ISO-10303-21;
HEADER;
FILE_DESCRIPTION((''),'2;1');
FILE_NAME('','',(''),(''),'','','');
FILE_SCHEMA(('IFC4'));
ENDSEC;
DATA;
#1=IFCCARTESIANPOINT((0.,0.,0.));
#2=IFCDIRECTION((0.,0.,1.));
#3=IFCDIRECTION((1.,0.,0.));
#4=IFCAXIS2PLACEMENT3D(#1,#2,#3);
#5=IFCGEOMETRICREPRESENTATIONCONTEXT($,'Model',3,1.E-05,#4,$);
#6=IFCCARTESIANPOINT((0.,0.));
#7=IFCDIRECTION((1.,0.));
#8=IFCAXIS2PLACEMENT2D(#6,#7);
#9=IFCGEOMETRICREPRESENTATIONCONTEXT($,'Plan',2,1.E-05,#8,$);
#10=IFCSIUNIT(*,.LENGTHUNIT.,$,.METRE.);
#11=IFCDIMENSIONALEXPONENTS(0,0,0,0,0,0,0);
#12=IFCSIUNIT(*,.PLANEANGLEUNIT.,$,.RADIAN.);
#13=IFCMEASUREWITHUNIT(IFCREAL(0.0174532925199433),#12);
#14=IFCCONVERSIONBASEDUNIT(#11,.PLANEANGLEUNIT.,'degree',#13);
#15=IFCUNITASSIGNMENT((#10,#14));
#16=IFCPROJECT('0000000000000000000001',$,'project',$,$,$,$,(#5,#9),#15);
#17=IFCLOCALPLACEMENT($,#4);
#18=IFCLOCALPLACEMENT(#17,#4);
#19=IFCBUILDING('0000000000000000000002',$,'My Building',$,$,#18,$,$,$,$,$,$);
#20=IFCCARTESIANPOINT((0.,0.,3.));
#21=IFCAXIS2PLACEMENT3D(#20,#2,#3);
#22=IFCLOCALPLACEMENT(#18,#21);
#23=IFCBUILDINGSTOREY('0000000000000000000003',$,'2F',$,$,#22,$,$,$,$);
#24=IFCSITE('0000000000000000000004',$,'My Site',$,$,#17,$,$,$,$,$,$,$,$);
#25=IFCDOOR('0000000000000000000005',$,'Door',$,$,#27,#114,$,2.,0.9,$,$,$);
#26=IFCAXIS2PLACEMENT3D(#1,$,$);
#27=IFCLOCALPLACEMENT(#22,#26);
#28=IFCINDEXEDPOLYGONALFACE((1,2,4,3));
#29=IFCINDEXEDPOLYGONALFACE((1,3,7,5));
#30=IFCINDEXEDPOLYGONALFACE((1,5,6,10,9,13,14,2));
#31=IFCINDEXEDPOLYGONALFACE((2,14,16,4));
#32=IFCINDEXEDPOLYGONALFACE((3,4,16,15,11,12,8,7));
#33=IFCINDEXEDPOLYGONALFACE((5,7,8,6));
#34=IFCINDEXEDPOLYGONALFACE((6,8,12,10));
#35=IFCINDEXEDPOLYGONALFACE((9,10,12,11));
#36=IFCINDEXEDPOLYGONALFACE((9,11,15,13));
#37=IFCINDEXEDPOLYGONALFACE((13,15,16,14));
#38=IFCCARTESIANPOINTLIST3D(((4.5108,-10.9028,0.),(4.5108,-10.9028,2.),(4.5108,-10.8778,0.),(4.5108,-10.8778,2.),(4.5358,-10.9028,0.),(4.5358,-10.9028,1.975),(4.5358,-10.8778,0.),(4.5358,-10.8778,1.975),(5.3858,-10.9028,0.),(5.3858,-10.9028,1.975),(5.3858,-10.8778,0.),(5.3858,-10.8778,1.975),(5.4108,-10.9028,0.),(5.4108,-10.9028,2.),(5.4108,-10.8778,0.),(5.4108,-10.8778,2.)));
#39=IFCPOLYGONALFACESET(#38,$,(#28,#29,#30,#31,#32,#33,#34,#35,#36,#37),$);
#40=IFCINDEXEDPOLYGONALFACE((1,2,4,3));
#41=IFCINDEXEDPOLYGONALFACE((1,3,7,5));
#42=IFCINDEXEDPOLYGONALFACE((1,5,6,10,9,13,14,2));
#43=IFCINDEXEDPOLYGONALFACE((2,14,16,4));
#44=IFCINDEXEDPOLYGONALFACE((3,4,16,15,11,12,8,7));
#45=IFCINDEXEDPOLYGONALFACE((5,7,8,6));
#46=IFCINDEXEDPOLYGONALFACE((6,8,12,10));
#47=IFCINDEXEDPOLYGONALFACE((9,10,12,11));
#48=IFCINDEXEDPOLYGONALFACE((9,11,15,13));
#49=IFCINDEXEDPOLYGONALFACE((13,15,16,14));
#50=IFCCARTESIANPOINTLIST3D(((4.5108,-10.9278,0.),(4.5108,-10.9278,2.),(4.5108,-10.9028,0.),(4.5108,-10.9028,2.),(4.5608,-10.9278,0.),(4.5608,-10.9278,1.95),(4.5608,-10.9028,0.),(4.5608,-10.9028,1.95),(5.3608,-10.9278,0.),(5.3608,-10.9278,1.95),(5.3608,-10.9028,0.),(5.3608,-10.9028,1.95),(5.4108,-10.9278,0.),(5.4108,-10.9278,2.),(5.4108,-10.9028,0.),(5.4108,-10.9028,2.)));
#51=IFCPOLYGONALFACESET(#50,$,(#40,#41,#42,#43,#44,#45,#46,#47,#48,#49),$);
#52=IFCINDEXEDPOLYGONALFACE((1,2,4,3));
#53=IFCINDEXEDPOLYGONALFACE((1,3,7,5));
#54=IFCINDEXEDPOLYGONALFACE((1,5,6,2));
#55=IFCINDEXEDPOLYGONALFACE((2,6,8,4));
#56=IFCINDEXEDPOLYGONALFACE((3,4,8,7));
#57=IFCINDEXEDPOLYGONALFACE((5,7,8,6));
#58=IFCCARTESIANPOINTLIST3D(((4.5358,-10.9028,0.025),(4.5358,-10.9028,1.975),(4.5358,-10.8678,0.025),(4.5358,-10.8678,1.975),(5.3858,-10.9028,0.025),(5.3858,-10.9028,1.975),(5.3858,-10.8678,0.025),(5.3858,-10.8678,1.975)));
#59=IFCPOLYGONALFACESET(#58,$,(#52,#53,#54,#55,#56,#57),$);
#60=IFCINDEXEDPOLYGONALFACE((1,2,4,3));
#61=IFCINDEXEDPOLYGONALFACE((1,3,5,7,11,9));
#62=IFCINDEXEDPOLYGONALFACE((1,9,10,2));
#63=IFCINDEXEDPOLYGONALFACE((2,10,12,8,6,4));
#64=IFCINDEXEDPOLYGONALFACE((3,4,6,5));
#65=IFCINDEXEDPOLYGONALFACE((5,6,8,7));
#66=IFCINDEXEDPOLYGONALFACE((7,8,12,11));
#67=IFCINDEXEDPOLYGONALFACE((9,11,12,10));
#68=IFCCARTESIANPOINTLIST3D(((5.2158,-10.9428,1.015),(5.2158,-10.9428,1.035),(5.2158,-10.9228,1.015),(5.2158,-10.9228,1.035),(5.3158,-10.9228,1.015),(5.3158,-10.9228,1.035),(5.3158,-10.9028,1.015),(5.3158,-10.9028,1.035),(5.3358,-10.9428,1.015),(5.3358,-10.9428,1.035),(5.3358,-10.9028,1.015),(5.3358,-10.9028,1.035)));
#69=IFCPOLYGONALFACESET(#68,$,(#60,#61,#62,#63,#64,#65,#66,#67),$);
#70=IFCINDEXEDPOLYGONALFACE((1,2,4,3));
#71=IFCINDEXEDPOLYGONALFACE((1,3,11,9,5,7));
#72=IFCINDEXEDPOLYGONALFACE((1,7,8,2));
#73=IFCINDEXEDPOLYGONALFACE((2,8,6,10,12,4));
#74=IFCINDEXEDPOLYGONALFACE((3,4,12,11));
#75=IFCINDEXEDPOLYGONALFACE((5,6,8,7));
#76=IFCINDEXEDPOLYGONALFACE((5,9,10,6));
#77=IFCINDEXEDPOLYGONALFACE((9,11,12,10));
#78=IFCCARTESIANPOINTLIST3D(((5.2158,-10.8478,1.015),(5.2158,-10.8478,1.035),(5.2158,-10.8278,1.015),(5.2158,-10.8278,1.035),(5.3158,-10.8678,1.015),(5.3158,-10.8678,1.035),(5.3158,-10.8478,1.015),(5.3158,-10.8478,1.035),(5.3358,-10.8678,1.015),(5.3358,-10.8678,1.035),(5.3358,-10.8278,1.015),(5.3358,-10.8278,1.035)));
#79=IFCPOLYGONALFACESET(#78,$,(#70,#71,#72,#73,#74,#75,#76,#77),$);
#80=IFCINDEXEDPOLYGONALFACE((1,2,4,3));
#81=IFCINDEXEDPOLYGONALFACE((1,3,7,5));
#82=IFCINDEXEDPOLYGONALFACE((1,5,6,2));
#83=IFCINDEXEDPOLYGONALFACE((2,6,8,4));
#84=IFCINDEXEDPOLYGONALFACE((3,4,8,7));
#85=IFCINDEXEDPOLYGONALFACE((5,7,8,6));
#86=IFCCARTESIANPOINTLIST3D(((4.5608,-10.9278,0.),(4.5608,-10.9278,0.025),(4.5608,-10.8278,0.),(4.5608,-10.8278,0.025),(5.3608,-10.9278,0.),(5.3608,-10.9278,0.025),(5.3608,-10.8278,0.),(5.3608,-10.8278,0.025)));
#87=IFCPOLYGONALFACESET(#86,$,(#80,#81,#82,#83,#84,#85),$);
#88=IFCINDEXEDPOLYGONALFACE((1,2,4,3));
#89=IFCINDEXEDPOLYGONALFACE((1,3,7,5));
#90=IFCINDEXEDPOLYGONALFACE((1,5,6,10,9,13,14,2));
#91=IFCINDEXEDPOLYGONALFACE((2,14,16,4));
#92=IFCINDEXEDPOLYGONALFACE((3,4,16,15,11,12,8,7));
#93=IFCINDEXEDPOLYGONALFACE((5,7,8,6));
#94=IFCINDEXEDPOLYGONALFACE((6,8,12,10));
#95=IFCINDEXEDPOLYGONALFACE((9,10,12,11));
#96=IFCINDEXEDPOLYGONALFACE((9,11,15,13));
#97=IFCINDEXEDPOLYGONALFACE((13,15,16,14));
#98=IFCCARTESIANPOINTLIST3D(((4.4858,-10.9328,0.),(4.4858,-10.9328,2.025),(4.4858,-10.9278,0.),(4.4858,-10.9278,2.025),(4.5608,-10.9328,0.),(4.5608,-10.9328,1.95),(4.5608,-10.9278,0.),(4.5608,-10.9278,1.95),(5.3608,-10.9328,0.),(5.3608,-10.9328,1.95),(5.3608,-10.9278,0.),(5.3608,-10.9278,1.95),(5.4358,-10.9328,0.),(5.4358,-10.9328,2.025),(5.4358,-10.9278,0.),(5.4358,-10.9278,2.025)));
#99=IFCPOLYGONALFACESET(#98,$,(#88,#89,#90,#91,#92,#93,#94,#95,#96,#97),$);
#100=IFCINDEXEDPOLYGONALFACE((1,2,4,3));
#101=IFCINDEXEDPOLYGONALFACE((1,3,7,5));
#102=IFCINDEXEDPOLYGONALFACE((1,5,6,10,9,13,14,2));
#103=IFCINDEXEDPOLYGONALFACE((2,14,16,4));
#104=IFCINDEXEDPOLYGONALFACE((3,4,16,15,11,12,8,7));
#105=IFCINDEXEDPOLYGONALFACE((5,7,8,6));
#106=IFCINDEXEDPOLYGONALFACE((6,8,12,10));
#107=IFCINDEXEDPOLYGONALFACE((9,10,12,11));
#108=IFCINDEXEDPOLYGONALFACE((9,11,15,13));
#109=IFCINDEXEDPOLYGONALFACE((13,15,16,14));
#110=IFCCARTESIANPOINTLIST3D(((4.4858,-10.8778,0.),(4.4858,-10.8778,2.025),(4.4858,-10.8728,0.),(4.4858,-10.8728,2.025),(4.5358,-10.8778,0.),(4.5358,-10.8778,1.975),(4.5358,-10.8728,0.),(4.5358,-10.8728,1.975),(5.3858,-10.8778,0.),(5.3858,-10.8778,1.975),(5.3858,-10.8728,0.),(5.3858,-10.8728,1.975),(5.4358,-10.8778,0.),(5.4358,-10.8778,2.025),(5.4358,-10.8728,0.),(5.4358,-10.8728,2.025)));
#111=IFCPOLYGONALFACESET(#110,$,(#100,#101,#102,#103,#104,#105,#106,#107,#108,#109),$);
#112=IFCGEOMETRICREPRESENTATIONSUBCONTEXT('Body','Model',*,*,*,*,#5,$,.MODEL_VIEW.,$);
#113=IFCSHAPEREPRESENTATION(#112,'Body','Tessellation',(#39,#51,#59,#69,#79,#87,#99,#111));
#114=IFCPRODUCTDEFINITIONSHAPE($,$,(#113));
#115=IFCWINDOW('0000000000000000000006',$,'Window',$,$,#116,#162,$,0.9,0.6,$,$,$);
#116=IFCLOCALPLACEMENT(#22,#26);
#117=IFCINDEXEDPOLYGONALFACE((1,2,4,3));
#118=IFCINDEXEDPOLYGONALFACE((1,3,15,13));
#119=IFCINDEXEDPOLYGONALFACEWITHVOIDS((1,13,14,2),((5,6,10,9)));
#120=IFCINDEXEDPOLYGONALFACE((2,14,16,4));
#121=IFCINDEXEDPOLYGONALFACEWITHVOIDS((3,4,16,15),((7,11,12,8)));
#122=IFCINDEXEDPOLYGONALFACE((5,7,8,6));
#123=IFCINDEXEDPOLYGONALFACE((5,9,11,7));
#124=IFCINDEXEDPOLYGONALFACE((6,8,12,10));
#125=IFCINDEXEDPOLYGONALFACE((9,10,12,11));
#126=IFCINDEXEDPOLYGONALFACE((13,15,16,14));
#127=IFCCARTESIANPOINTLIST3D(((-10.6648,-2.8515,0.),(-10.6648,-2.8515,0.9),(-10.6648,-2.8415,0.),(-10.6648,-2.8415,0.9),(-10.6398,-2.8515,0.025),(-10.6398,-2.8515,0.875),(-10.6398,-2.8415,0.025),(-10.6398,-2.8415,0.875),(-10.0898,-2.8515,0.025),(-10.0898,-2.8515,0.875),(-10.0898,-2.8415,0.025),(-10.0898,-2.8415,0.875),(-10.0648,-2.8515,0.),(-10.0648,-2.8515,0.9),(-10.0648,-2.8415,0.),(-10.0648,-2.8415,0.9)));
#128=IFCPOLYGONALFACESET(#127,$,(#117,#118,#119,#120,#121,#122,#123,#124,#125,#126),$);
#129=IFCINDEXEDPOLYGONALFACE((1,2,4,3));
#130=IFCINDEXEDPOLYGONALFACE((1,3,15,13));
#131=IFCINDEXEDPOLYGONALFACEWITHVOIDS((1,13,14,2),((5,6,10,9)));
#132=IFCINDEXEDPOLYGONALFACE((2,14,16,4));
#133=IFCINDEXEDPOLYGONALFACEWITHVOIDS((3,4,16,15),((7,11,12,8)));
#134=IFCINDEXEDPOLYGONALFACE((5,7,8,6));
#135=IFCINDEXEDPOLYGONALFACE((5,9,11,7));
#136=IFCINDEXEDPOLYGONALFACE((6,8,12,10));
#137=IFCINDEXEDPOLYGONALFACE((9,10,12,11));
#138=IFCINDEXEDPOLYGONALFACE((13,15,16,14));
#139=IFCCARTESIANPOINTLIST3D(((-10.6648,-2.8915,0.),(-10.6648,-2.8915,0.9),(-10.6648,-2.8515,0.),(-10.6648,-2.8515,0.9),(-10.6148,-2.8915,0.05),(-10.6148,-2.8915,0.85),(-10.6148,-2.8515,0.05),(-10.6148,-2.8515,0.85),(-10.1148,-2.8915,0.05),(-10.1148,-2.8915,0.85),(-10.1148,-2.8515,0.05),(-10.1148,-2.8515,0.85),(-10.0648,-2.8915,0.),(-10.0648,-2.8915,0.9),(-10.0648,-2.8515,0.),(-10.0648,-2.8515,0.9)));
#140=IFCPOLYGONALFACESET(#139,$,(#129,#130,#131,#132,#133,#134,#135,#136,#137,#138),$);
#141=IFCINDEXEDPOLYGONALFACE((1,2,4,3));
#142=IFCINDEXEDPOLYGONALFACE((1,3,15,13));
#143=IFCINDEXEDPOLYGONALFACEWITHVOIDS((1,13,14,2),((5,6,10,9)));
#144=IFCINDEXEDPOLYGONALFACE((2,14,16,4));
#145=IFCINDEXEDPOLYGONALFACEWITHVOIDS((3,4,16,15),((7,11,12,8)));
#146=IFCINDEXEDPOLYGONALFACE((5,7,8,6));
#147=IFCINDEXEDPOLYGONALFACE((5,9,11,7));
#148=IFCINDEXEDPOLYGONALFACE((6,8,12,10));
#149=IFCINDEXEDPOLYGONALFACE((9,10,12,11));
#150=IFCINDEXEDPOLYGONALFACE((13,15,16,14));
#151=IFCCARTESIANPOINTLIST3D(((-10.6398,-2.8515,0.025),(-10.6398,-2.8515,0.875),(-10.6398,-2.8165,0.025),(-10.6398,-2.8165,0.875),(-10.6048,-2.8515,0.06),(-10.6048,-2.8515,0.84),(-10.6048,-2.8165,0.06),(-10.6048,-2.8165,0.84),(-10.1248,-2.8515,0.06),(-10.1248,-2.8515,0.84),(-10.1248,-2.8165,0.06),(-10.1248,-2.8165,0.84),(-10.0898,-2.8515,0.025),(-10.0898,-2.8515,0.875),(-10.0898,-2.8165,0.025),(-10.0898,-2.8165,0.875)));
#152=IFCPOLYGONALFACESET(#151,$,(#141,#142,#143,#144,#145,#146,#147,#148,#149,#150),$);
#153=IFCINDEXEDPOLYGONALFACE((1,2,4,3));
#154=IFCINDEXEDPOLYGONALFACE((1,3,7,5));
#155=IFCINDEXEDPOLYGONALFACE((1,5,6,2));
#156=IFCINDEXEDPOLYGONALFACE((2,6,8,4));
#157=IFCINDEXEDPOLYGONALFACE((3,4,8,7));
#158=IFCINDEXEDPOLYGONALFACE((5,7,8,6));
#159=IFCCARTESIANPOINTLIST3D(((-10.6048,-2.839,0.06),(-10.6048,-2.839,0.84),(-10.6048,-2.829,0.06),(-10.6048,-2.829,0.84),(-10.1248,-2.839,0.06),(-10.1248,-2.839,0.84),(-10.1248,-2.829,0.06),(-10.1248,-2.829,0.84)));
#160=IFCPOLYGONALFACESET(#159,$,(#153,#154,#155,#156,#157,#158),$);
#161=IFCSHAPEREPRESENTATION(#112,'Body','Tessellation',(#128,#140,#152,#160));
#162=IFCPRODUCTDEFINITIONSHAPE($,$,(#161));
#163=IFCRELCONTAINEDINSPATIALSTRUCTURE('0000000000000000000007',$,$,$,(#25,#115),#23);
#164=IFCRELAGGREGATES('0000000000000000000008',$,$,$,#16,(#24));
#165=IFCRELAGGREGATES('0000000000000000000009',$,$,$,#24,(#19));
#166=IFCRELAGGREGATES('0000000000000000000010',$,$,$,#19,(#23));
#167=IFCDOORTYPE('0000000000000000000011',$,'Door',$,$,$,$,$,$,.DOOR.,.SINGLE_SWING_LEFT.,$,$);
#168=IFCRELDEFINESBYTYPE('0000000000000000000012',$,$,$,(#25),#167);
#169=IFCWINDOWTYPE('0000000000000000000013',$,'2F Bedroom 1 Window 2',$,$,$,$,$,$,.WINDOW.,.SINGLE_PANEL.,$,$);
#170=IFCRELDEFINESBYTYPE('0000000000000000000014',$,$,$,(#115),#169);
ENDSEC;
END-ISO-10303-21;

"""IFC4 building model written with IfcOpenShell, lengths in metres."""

from ifc_helpers import new_model, entity, si_unit, converted_unit, frame, origin_with_axes, origin_2d_with_axis, place, context, subcontext, project, spatial, line, indexed_curve, outline, extrude, shape, source, transform, mapped, type_object, type_shapes, element, save


model = new_model("IFC4")

# Units and contexts
model_context = context("Model", 3, precision=1e-05, world=origin_with_axes())
plan_context = context("Plan", 2, precision=1e-05, world=origin_2d_with_axis())
body_context_1 = subcontext(model_context, "Body", "Model", "MODEL_VIEW")
body_context_2 = subcontext(plan_context, "Body", "Plan", "PLAN_VIEW")
ifc_project = project(units=[si_unit("LENGTHUNIT", "METRE"), converted_unit("PLANEANGLEUNIT", "degree", entity("IfcReal", 0.0174532925199433), si_unit("PLANEANGLEUNIT", "RADIAN"), dimensions=[0, 0, 0, 0, 0, 0, 0])], contexts=[model_context, plan_context])

# Site, building, storey
site_placement = place(None, origin_with_axes())
site = spatial("IfcSite", under=ifc_project, at=site_placement, Name="My Site")
building_placement = place(site_placement, origin_with_axes())
building = spatial("IfcBuilding", under=site, at=building_placement, Name="My Building")
storey_placement = place(building_placement, frame((0.0, 0.0, 3.0), z_axis=(0.0, 0.0, 1.0), x_axis=(1.0, 0.0, 0.0)))
storey = spatial("IfcBuildingStorey", under=building, at=storey_placement, Name="2F")

# Shared definitions
door_type_1 = type_object("IfcDoorType", Name="Door", OperationType="SINGLE_SWING_LEFT", PredefinedType="DOOR")
shared_shape_1 = source(origin_with_axes(), body_context_1, "Body", "SweptSolid", [
    extrude(outline(indexed_curve([(0.0, 0.0), (0.0, 2.0), (0.9, 2.0), (0.9, 0.0), (0.875, 0.0), (0.875, 1.975), (0.025, 1.975), (0.025, 0.0)], segments=[line(1, 2, 3, 4, 5, 6, 7, 8, 1)])), frame((0.0, 0.025, 0.0), z_axis=(0.0, -1.0, 0.0), x_axis=(1.0, 0.0, 0.0)), (0.0, 0.0, -1.0), 0.025),
    extrude(outline(indexed_curve([(0.0, 0.0), (0.0, 2.0), (0.9, 2.0), (0.9, 0.0), (0.85, 0.0), (0.85, 1.95), (0.05, 1.95), (0.05, 0.0)], segments=[line(1, 2, 3, 4, 5, 6, 7, 8, 1)])), frame((0.0, 0.0, 0.0), z_axis=(0.0, -1.0, 0.0), x_axis=(1.0, 0.0, 0.0)), (0.0, 0.0, -1.0), 0.025),
    extrude(outline(indexed_curve([(0.0, 0.0), (0.85, 0.0), (0.85, 0.035), (0.0, 0.035)], segments=[line(1, 2, 3, 4, 1)])), frame((0.025, 0.025, 0.025), z_axis=(0.0, 0.0, 1.0), x_axis=(1.0, 0.0, 0.0)), (0.0, 0.0, 1.0), 1.95),
    extrude(outline(indexed_curve([(0.0, 0.0), (0.0, -0.04), (-0.12, -0.04), (-0.12, -0.02), (-0.02, -0.02), (-0.02, 0.0)], segments=[line(1, 2, 3, 4, 5, 6, 1)])), frame((0.825, 0.025, 1.015), z_axis=(0.0, 0.0, 1.0), x_axis=(1.0, 0.0, 0.0)), (0.0, 0.0, 1.0), 0.02),
    extrude(outline(indexed_curve([(0.0, 0.0), (0.0, 0.04), (-0.12, 0.04), (-0.12, 0.02), (-0.02, 0.02), (-0.02, 0.0)], segments=[line(1, 2, 3, 4, 5, 6, 1)])), frame((0.825, 0.06, 1.015), z_axis=(0.0, 0.0, 1.0), x_axis=(1.0, 0.0, 0.0)), (0.0, 0.0, 1.0), 0.02),
    extrude(outline(indexed_curve([(0.0, 0.0), (0.8, 0.0), (0.8, 0.1), (0.0, 0.1)], segments=[line(1, 2, 3, 4, 1)])), frame((0.05, 0.0, 0.0), z_axis=(0.0, 0.0, 1.0), x_axis=(1.0, 0.0, 0.0)), (0.0, 0.0, 1.0), 0.025),
    extrude(outline(indexed_curve([(0.0, 0.0), (0.0, 2.025), (0.95, 2.025), (0.95, 0.0), (0.875, 0.0), (0.875, 1.95), (0.075, 1.95), (0.075, 0.0)], segments=[line(1, 2, 3, 4, 5, 6, 7, 8, 1)])), frame((-0.025, -0.005, 0.0), z_axis=(0.0, -1.0, 0.0), x_axis=(1.0, 0.0, 0.0)), (0.0, 0.0, -1.0), 0.005),
    extrude(outline(indexed_curve([(0.0, 0.0), (0.0, 2.025), (0.95, 2.025), (0.95, 0.0), (0.9, 0.0), (0.9, 1.975), (0.05, 1.975), (0.05, 0.0)], segments=[line(1, 2, 3, 4, 5, 6, 7, 8, 1)])), frame((-0.025, 0.05, 0.0), z_axis=(0.0, -1.0, 0.0), x_axis=(1.0, 0.0, 0.0)), (0.0, 0.0, -1.0), 0.005),
])
shared_shape_2 = source(origin_with_axes(), body_context_2, "Body", "Curve2D", [
    entity("IfcIndexedPolyCurve", entity("IfcCartesianPointList2D", [[0.0, 0.0], [0.0, 0.05], [0.025, 0.05], [0.025, 0.025], [0.05, 0.025], [0.05, 0.0]]), [entity("IfcLineIndex", [1, 2, 3, 4, 5, 6, 1])]),
    entity("IfcIndexedPolyCurve", entity("IfcCartesianPointList2D", [[0.9, 0.0], [0.9, 0.05], [0.875, 0.05], [0.875, 0.025], [0.85, 0.025], [0.85, 0.0]]), [entity("IfcLineIndex", [1, 2, 3, 4, 5, 6, 1])]),
    entity("IfcTrimmedCurve", entity("IfcEllipse", entity("IfcAxis2Placement2D", entity("IfcCartesianPoint", [0.06, 0.05]), entity("IfcDirection", [1.0, 0.0])), 0.815, 0.85), [entity("IfcCartesianPoint", [0.875, 0.05])], [entity("IfcCartesianPoint", [0.06, 0.9])], True, "CARTESIAN"),
    entity("IfcIndexedPolyCurve", entity("IfcCartesianPointList2D", [[0.025, 0.05], [0.06, 0.05], [0.06, 0.9], [0.025, 0.9]]), [entity("IfcLineIndex", [1, 2, 3, 4, 1])]),
])
type_shapes(door_type_1, [shared_shape_1, shared_shape_2])

# Door
for number, where, z_axis, x_axis, name in (
    (1, (4.5108, -10.9278, 0.0), (0.0, 0.0, 1.0), (1.0, 0.0, 0.0), "Door"),
):
    element("IfcDoor", number, at=place(storey_placement, frame(where, z_axis=z_axis, x_axis=x_axis)), inside=storey, type_object=door_type_1, Name=name, OverallHeight=2.0, OverallWidth=0.9, shapes=[
        shape(body_context_1, "Body", "MappedRepresentation", [mapped(shared_shape_1, transform((0.0, 0.0, 0.0), x_axis=(1.0, 0.0, 0.0), y_axis=(0.0, 1.0, 0.0), z_axis=(0.0, 0.0, 1.0), scale=1.0))]),
        shape(body_context_2, "Body", "MappedRepresentation", [mapped(shared_shape_2, transform((0.0, 0.0, 0.0), x_axis=(1.0, 0.0, 0.0), y_axis=(0.0, 1.0, 0.0), z_axis=(0.0, 0.0, 1.0), scale=1.0))]),
    ])

# Window
window_type_1 = type_object("IfcWindowType", Name="2F Bedroom 1 Window 2", PartitioningType="SINGLE_PANEL", PredefinedType="WINDOW")
shared_shape_3 = source(origin_with_axes(), body_context_1, "Body", "SweptSolid", [
    extrude(outline(indexed_curve([(0.0, 0.0), (0.6, 0.0), (0.6, 0.9), (0.0, 0.9)], segments=[line(1, 2, 3, 4, 1)]), holes=[indexed_curve([(0.025, 0.025), (0.575, 0.025), (0.575, 0.875), (0.025, 0.875)], segments=[line(1, 2, 3, 4, 1)])]), frame((0.0, 0.09, 0.0), z_axis=(0.0, -1.0, 0.0), x_axis=(1.0, 0.0, 0.0)), (0.0, 0.0, -1.0), 0.01),
    extrude(outline(indexed_curve([(0.0, 0.0), (0.6, 0.0), (0.6, 0.9), (0.0, 0.9)], segments=[line(1, 2, 3, 4, 1)]), holes=[indexed_curve([(0.05, 0.05), (0.55, 0.05), (0.55, 0.85), (0.05, 0.85)], segments=[line(1, 2, 3, 4, 1)])]), frame((0.0, 0.05, 0.0), z_axis=(0.0, -1.0, 0.0), x_axis=(1.0, 0.0, 0.0)), (0.0, 0.0, -1.0), 0.04),
    extrude(outline(indexed_curve([(0.0, 0.0), (0.55, 0.0), (0.55, 0.85), (0.0, 0.85)], segments=[line(1, 2, 3, 4, 1)]), holes=[indexed_curve([(0.035, 0.035), (0.515, 0.035), (0.515, 0.815), (0.035, 0.815)], segments=[line(1, 2, 3, 4, 1)])]), frame((0.025, 0.09, 0.025), z_axis=(0.0, -1.0, 0.0), x_axis=(1.0, 0.0, 0.0)), (0.0, 0.0, -1.0), 0.035),
    extrude(outline(indexed_curve([(0.035, 0.035), (0.515, 0.035), (0.515, 0.815), (0.035, 0.815)], segments=[line(1, 2, 3, 4, 1)])), frame((0.025, 0.1025, 0.025), z_axis=(0.0, -1.0, 0.0), x_axis=(1.0, 0.0, 0.0)), (0.0, 0.0, -1.0), 0.01),
])
shared_shape_4 = source(origin_with_axes(), body_context_2, "Body", "Curve2D", [
    entity("IfcIndexedPolyCurve", entity("IfcCartesianPointList2D", [[0.05, 0.05], [0.55, 0.05]])),
    entity("IfcIndexedPolyCurve", entity("IfcCartesianPointList2D", [[0.0, 0.1], [0.025, 0.1], [0.025, 0.09], [0.05, 0.09], [0.05, 0.05], [0.0, 0.05]]), [entity("IfcLineIndex", [1, 2, 3, 4, 5, 6, 1])]),
    entity("IfcIndexedPolyCurve", entity("IfcCartesianPointList2D", [[0.6, 0.1], [0.575, 0.1], [0.575, 0.09], [0.55, 0.09], [0.55, 0.05], [0.6, 0.05]]), [entity("IfcLineIndex", [1, 2, 3, 4, 5, 6, 1])]),
    entity("IfcIndexedPolyCurve", entity("IfcCartesianPointList2D", [[0.025, 0.09], [0.06, 0.09], [0.06, 0.125], [0.025, 0.125]]), [entity("IfcLineIndex", [1, 2, 3, 4, 1])]),
    entity("IfcIndexedPolyCurve", entity("IfcCartesianPointList2D", [[0.575, 0.09], [0.54, 0.09], [0.54, 0.125], [0.575, 0.125]]), [entity("IfcLineIndex", [1, 2, 3, 4, 1])]),
    entity("IfcIndexedPolyCurve", entity("IfcCartesianPointList2D", [[0.06, 0.09], [0.54, 0.09]])),
    entity("IfcIndexedPolyCurve", entity("IfcCartesianPointList2D", [[0.06, 0.125], [0.54, 0.125]])),
    entity("IfcIndexedPolyCurve", entity("IfcCartesianPointList2D", [[0.06, 0.1075], [0.54, 0.1075]])),
])
type_shapes(window_type_1, [shared_shape_3, shared_shape_4])
window_1_placement = place(storey_placement, frame((-10.6648, -2.9415, 0.0), z_axis=(0.0, 0.0, 1.0), x_axis=(1.0, 0.0, 0.0)))
element("IfcWindow", 2, at=window_1_placement, inside=storey, type_object=window_type_1, Name="Window", OverallHeight=0.9, OverallWidth=0.6, shapes=[
    shape(body_context_1, "Body", "MappedRepresentation", [mapped(shared_shape_3, transform((0.0, 0.0, 0.0), x_axis=(1.0, 0.0, 0.0), y_axis=(0.0, 1.0, 0.0), z_axis=(0.0, 0.0, 1.0), scale=1.0))]),
    shape(body_context_2, "Body", "MappedRepresentation", [mapped(shared_shape_4, transform((0.0, 0.0, 0.0), x_axis=(1.0, 0.0, 0.0), y_axis=(0.0, 1.0, 0.0), z_axis=(0.0, 0.0, 1.0), scale=1.0))]),
])

save(model, "model.ifc")
